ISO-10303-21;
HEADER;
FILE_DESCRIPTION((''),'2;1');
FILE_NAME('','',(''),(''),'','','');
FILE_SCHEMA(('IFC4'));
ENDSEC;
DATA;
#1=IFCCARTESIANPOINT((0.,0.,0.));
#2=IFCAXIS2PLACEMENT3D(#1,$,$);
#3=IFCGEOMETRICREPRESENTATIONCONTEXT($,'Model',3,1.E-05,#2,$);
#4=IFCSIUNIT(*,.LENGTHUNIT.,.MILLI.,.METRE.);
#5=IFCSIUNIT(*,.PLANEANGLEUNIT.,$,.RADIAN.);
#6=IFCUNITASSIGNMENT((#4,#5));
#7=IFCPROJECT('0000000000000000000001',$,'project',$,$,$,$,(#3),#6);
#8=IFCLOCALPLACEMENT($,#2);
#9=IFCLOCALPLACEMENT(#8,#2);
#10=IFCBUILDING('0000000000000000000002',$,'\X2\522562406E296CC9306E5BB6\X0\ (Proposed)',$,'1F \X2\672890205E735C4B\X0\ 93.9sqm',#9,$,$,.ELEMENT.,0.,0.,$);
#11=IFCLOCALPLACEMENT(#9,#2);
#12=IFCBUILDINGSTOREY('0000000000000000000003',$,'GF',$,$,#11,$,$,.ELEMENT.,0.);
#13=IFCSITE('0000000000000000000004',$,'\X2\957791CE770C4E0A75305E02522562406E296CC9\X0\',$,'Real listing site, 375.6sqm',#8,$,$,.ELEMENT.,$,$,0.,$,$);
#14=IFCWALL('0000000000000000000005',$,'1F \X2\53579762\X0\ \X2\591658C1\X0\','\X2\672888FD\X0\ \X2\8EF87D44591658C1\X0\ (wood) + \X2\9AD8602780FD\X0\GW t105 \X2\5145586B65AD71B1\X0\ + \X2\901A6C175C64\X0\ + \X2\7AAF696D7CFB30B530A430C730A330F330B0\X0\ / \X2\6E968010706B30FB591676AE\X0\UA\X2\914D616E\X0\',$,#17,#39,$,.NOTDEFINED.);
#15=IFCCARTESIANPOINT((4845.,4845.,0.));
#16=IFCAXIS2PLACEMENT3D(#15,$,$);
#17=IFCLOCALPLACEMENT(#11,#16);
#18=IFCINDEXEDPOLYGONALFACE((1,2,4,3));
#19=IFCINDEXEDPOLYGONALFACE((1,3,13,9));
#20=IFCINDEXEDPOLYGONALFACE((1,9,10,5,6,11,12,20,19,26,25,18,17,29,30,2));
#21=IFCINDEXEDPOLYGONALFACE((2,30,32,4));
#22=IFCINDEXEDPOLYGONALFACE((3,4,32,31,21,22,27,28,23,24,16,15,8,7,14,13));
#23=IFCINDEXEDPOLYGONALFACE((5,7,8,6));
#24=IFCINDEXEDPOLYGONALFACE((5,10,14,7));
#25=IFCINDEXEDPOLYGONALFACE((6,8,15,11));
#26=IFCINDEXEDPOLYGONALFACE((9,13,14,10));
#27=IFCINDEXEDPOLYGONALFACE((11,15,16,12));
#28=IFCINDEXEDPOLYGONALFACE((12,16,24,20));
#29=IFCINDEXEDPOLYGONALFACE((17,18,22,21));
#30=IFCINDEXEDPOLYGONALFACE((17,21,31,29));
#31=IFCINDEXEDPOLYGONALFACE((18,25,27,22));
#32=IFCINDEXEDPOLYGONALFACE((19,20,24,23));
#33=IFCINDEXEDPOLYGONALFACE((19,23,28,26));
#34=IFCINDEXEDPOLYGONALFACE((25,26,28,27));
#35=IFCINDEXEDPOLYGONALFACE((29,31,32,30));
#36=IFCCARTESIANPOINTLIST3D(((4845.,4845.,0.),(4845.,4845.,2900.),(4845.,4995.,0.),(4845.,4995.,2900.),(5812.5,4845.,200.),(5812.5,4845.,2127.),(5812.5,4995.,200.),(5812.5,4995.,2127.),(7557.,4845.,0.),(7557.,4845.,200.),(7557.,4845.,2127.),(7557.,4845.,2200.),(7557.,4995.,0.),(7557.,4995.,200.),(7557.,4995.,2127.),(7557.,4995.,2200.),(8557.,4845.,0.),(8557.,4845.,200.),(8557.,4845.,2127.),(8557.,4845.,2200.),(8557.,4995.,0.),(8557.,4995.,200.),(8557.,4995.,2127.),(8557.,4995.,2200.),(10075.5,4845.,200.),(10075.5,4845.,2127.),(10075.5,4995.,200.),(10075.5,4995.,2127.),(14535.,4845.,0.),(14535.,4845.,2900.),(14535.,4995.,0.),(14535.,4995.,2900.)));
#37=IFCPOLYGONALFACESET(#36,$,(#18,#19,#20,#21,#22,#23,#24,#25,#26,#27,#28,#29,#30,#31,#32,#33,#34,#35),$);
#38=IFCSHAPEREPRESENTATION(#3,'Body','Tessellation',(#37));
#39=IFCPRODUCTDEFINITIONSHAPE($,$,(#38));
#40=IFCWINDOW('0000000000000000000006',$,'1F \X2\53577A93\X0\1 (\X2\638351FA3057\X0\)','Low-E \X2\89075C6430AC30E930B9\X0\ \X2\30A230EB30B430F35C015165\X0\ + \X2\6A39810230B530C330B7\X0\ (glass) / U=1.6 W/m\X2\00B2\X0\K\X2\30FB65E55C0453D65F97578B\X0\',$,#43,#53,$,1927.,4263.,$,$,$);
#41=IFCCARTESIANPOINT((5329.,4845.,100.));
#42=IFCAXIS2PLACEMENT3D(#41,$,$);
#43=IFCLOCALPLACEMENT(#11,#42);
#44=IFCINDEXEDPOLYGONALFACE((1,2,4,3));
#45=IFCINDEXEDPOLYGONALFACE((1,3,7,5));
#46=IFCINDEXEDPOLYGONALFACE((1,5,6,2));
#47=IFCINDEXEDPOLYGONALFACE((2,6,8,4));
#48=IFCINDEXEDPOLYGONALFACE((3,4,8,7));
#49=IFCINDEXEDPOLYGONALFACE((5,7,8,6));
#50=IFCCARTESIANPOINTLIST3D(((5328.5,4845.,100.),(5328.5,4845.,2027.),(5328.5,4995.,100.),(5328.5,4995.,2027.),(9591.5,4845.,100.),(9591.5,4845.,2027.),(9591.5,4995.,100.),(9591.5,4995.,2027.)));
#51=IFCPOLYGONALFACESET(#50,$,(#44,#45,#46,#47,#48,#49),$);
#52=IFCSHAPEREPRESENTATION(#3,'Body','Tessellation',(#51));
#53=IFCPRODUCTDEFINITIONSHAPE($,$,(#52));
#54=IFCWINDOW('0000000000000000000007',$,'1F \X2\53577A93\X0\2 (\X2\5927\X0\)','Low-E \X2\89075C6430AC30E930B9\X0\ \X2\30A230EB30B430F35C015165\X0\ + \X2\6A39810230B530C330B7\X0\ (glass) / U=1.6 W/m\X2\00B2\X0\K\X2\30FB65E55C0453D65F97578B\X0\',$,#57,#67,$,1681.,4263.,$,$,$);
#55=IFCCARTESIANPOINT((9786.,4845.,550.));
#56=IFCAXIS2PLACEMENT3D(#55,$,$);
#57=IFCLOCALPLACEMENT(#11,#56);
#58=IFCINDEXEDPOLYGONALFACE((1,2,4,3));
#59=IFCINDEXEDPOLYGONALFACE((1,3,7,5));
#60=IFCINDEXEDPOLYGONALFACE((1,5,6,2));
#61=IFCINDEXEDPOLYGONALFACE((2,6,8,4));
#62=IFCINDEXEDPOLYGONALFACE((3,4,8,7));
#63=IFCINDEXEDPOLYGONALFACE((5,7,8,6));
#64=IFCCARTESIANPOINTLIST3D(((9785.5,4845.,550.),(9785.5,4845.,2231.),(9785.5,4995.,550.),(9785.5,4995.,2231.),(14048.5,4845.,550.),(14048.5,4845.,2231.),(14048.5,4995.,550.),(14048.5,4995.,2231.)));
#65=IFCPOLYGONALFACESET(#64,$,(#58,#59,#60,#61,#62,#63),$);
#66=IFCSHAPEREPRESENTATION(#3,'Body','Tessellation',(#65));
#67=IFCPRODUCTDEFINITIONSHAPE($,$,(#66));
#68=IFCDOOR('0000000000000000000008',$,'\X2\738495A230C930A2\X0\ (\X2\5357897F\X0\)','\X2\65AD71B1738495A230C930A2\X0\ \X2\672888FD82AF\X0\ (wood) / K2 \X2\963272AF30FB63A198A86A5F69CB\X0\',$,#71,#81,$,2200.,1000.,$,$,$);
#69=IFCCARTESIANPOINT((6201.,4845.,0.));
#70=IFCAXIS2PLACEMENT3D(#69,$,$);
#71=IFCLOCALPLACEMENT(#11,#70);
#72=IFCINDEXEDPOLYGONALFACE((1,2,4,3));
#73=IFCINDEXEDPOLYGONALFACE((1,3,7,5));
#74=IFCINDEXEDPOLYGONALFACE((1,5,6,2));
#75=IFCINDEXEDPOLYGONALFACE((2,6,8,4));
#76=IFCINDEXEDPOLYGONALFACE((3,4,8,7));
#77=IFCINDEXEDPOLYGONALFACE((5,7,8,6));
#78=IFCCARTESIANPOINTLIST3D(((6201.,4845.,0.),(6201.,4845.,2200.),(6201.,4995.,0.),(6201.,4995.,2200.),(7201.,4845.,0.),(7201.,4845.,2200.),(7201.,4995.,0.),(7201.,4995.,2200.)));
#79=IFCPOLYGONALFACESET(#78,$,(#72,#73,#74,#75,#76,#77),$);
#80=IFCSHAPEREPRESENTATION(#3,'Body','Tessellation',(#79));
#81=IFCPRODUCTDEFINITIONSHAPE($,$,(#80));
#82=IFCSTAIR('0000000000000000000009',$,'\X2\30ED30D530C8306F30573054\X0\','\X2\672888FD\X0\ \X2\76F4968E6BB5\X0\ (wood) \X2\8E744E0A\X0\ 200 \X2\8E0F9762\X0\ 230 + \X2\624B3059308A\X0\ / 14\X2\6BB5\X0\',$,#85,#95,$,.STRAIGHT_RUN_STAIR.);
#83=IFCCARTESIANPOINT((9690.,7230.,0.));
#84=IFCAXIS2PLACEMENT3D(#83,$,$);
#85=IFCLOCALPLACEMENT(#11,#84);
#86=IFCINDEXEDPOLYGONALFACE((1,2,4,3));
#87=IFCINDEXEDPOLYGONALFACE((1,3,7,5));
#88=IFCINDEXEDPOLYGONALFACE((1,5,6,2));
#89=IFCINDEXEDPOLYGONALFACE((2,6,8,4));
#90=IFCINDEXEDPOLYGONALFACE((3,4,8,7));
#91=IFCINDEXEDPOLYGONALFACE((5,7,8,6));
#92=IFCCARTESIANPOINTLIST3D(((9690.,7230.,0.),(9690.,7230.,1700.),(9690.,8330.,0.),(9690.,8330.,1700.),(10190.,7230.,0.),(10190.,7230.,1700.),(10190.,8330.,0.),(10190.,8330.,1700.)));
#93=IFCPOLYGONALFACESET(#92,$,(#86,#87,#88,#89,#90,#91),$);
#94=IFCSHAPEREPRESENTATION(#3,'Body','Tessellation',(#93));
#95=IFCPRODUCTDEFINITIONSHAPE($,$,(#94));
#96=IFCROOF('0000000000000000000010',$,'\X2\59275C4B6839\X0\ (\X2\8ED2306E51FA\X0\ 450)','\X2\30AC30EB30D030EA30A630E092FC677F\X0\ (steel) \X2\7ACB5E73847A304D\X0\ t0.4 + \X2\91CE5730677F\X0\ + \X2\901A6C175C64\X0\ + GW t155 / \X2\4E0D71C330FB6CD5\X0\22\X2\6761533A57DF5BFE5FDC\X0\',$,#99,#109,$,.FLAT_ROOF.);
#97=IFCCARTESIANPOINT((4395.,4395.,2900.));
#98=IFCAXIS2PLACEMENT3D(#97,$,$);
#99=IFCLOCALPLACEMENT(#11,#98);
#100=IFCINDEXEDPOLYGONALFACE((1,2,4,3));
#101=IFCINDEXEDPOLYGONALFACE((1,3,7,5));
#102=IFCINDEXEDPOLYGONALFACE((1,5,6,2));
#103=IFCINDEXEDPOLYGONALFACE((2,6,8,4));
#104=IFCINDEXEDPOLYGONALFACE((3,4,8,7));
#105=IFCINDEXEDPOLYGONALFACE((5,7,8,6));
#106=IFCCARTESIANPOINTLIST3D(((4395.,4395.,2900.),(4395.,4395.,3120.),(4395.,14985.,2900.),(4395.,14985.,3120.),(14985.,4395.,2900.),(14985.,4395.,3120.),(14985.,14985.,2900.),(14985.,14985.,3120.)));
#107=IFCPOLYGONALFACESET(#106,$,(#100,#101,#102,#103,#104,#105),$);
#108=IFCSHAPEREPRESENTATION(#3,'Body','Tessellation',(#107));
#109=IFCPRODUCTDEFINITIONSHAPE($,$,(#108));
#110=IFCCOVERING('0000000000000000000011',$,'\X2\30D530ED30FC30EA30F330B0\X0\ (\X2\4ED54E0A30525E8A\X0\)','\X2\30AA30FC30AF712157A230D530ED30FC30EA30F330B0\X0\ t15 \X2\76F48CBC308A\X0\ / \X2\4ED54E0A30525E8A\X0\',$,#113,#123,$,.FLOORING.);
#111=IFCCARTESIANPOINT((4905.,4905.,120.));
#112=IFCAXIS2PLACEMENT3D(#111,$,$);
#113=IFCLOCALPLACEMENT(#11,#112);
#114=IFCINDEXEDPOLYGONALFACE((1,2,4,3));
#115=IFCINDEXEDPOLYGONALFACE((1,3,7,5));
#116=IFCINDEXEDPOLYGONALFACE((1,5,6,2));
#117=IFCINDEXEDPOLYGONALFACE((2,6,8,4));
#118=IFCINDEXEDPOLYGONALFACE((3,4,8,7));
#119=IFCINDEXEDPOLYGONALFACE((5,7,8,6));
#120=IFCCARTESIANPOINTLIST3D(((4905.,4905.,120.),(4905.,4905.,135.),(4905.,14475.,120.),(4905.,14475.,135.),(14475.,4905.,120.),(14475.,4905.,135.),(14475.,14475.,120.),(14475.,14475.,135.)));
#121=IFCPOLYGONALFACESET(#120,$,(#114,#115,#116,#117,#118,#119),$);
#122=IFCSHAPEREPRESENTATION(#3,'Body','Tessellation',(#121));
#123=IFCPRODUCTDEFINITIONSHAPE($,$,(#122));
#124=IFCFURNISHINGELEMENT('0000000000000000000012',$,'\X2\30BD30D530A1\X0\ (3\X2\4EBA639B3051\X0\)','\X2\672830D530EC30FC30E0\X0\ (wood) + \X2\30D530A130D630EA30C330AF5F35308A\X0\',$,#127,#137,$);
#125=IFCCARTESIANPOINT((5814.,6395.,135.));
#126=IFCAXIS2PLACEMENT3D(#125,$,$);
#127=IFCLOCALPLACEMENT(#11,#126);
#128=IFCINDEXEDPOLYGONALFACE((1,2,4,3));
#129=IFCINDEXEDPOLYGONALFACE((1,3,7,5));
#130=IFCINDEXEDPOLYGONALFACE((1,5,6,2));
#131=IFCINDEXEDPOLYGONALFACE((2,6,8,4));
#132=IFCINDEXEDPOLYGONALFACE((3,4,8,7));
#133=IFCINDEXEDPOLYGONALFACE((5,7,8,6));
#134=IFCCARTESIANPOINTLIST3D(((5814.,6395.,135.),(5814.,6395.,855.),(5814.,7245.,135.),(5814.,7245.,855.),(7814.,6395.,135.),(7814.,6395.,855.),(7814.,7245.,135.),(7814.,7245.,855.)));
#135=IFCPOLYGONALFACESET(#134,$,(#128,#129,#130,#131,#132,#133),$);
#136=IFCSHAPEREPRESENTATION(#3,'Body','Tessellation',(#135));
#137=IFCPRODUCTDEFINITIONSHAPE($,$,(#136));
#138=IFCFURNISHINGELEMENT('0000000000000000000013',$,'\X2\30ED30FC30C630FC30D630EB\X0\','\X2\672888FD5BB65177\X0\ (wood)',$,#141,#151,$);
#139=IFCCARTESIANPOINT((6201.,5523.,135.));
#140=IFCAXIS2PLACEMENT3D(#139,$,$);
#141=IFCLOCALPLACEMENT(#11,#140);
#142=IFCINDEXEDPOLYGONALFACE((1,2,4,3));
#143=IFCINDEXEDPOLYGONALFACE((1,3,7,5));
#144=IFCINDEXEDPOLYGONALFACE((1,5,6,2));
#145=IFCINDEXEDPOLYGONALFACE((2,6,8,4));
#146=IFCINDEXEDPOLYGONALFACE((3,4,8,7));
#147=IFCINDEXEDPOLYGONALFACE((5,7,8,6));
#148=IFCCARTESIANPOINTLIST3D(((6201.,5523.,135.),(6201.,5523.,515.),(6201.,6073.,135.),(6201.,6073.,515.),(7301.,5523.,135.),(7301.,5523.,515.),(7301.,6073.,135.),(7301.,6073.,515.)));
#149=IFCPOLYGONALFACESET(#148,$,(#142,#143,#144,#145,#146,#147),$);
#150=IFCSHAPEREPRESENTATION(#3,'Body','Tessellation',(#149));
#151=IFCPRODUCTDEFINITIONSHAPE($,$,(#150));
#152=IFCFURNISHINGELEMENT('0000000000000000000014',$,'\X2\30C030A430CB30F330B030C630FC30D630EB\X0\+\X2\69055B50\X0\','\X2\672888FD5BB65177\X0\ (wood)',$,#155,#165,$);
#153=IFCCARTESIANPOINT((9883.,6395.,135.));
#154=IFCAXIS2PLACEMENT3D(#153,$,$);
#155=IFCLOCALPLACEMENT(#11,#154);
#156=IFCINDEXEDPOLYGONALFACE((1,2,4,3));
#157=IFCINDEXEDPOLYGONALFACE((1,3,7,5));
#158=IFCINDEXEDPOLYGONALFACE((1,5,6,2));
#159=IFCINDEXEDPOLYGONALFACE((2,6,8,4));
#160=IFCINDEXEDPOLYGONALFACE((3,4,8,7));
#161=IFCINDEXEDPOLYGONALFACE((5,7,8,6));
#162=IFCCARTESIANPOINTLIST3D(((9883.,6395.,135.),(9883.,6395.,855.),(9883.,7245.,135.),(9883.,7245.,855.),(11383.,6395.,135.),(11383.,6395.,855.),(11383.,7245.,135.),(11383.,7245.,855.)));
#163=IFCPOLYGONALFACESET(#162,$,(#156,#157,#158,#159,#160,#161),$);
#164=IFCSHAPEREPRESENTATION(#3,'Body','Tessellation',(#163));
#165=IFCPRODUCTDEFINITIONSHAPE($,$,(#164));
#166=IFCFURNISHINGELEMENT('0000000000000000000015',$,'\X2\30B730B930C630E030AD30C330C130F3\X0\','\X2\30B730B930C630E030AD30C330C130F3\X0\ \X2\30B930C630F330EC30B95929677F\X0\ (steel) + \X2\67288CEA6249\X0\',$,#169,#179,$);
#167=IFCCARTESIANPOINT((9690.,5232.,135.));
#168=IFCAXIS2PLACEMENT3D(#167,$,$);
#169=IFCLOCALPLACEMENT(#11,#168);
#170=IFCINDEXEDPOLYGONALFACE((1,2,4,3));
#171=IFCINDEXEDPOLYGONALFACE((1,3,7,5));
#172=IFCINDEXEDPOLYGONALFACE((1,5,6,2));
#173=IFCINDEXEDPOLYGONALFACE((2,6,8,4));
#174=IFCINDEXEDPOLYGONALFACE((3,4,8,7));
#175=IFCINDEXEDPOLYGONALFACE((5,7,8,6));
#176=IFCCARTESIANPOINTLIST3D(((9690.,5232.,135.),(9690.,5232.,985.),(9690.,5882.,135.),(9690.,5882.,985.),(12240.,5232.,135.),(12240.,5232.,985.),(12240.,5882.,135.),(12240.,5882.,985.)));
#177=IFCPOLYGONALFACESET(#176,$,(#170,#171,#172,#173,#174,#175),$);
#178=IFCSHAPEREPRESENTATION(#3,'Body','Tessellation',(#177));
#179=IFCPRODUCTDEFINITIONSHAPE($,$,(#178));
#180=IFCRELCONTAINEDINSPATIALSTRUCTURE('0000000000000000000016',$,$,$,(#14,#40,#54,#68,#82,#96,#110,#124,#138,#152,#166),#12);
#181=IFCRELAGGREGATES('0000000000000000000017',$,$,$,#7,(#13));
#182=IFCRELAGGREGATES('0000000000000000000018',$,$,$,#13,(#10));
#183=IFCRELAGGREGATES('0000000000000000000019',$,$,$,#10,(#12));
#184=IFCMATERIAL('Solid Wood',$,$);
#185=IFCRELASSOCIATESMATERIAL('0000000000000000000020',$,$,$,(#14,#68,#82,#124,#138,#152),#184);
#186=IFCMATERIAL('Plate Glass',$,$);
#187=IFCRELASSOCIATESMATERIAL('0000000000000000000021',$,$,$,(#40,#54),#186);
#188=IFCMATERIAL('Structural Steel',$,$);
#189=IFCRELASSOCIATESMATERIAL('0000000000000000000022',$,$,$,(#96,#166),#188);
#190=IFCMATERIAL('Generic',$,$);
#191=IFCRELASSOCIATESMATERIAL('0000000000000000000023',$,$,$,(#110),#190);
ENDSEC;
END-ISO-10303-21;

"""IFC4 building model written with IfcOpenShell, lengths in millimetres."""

from ifc_helpers import new_model, si_unit, frame, frame_2d, origin, place, context, project, spatial, rectangle, extrude, material, element, fill, save


model = new_model("IFC4")

# Units and contexts
model_context = context("Model", 3, precision=1e-05, world=origin())
ifc_project = project(units=[si_unit("LENGTHUNIT", "METRE", prefix="MILLI"), si_unit("PLANEANGLEUNIT", "RADIAN")], contexts=[model_context])

# Site, building, storey
site_placement = place(None, origin())
site = spatial("IfcSite", under=ifc_project, at=site_placement, Name="長野県上田市別所温泉", ObjectType="Real listing site, 375.6sqm", CompositionType="ELEMENT", RefElevation=0.0)
building_placement = place(site_placement, origin())
building = spatial("IfcBuilding", under=site, at=building_placement, Name="別所温泉の家 (Proposed)", ObjectType="1F 木造平屋 93.9sqm", CompositionType="ELEMENT", ElevationOfRefHeight=0.0, ElevationOfTerrain=0.0)
storey_placement = place(building_placement, origin())
storey = spatial("IfcBuildingStorey", under=building, at=storey_placement, Name="GF", CompositionType="ELEMENT", Elevation=0.0)

# Shared definitions
ifc_material_1 = material(Name="Solid Wood")

# Wall, openings, windows, door
wall_1_placement = place(storey_placement, frame((4845.0, 4845.0, 0.0)))
wall_1 = element("IfcWall", 1, at=wall_1_placement, inside=storey, material=ifc_material_1, Name="1F 南面 外壁", Description="木製 軸組外壁 (wood) + 高性能GW t105 充填断熱 + 通気層 + 窯業系サイディング / 準耐火・外皮UA配慮", PredefinedType="NOTDEFINED", context=model_context, shape_type="SweptSolid", body=[
    extrude(rectangle(XDim=9690.0, YDim=150.0, at=frame_2d((4845.0, 75.0))), frame((4845.0, 4845.0, 0.0)), (0.0, 0.0, 1.0), 2900.0),
])
opening_1_placement = place(storey_placement, frame((5329.0, 4845.0, 100.0)))
opening_1 = element("IfcOpeningElement", 2, at=opening_1_placement, cuts=wall_1, PredefinedType="NOTDEFINED", context=model_context, shape_type="SweptSolid", body=[
    extrude(rectangle(XDim=4263.0, YDim=150.0, at=frame_2d((2131.0, 75.0))), frame((5329.0, 4845.0, 100.0)), (0.0, 0.0, 1.0), 1927.0),
])
opening_2_placement = place(storey_placement, frame((9786.0, 4845.0, 550.0)))
opening_2 = element("IfcOpeningElement", 3, at=opening_2_placement, cuts=wall_1, PredefinedType="NOTDEFINED", context=model_context, shape_type="SweptSolid", body=[
    extrude(rectangle(XDim=4263.0, YDim=150.0, at=frame_2d((2131.0, 75.0))), frame((9786.0, 4845.0, 550.0)), (0.0, 0.0, 1.0), 1681.0),
])
opening_3_placement = place(storey_placement, frame((6201.0, 4845.0, 0.0)))
opening_3 = element("IfcOpeningElement", 4, at=opening_3_placement, cuts=wall_1, PredefinedType="NOTDEFINED", context=model_context, shape_type="SweptSolid", body=[
    extrude(rectangle(XDim=1000.0, YDim=150.0, at=frame_2d((500.0, 75.0))), frame((6201.0, 4845.0, 0.0)), (0.0, 0.0, 1.0), 2200.0),
])
ifc_material_2 = material(Name="Plate Glass")
window_1_placement = place(storey_placement, frame((5329.0, 4845.0, 100.0)))
window_1 = element("IfcWindow", 5, at=window_1_placement, inside=storey, material=ifc_material_2, Name="1F 南窓1 (掃出し)", Description="Low-E 複層ガラス アルゴン封入 + 樹脂サッシ (glass) / U=1.6 W/m²K・日射取得型", OverallHeight=1927.0, OverallWidth=4263.0, context=model_context, shape_type="SweptSolid", body=[
    extrude(rectangle(XDim=4263.0, YDim=150.0, at=frame_2d((2131.0, 75.0))), frame((5329.0, 4845.0, 100.0)), (0.0, 0.0, 1.0), 1927.0),
])
fill(opening_1, window_1)
window_2_placement = place(storey_placement, frame((9786.0, 4845.0, 550.0)))
window_2 = element("IfcWindow", 6, at=window_2_placement, inside=storey, material=ifc_material_2, Name="1F 南窓2 (大)", Description="Low-E 複層ガラス アルゴン封入 + 樹脂サッシ (glass) / U=1.6 W/m²K・日射取得型", OverallHeight=1681.0, OverallWidth=4263.0, context=model_context, shape_type="SweptSolid", body=[
    extrude(rectangle(XDim=4263.0, YDim=150.0, at=frame_2d((2131.0, 75.0))), frame((9786.0, 4845.0, 550.0)), (0.0, 0.0, 1.0), 1681.0),
])
fill(opening_2, window_2)
door_placement = place(storey_placement, frame((6201.0, 4845.0, 0.0)))
door = element("IfcDoor", 7, at=door_placement, inside=storey, material=ifc_material_1, Name="玄関ドア (南西)", Description="断熱玄関ドア 木製芯 (wood) / K2 防犯・採風機構", OverallHeight=2200.0, OverallWidth=1000.0, context=model_context, shape_type="SweptSolid", body=[
    extrude(rectangle(XDim=1000.0, YDim=150.0, at=frame_2d((500.0, 75.0))), frame((6201.0, 4845.0, 0.0)), (0.0, 0.0, 1.0), 2200.0),
])
fill(opening_3, door)

# Stair
stair_placement = place(storey_placement, frame((9690.0, 7230.0, 0.0)))
element("IfcStair", 8, at=stair_placement, inside=storey, material=ifc_material_1, Name="ロフトはしご", Description="木製 直階段 (wood) 蹴上 200 踏面 230 + 手すり / 14段", PredefinedType="STRAIGHT_RUN_STAIR", context=model_context, shape_type="SweptSolid", body=[
    extrude(rectangle(XDim=500.0, YDim=1100.0, at=frame_2d((250.0, 550.0))), frame((9690.0, 7230.0, 0.0)), (0.0, 0.0, 1.0), 1700.0),
])

# Roof
ifc_material_3 = material(Name="Structural Steel")
roof_placement = place(storey_placement, frame((4395.0, 4395.0, 2900.0)))
element("IfcRoof", 9, at=roof_placement, inside=storey, material=ifc_material_3, Name="大屋根 (軒の出 450)", Description="ガルバリウム鋼板 (steel) 立平葺き t0.4 + 野地板 + 通気層 + GW t155 / 不燃・法22条区域対応", PredefinedType="FLAT_ROOF", context=model_context, shape_type="SweptSolid", body=[
    extrude(rectangle(XDim=10590.0, YDim=10590.0, at=frame_2d((5295.0, 5295.0))), frame((4395.0, 4395.0, 2900.0)), (0.0, 0.0, 1.0), 220.0),
])

# Covering
ifc_material_4 = material(Name="Generic")
covering_placement = place(storey_placement, frame((4905.0, 4905.0, 120.0)))
element("IfcCovering", 10, at=covering_placement, inside=storey, material=ifc_material_4, Name="フローリング (仕上げ床)", Description="オーク無垢フローリング t15 直貼り / 仕上げ床", PredefinedType="FLOORING", context=model_context, shape_type="SweptSolid", body=[
    extrude(rectangle(XDim=9570.0, YDim=9570.0, at=frame_2d((4785.0, 4785.0))), frame((4905.0, 4905.0, 120.0)), (0.0, 0.0, 1.0), 15.0),
])

# Furnishing elements
furnishing_1_placement = place(storey_placement, frame((5814.0, 6395.0, 135.0)))
element("IfcFurnishingElement", 11, at=furnishing_1_placement, inside=storey, material=ifc_material_1, Name="ソファ (3人掛け)", Description="木フレーム (wood) + ファブリック張り", context=model_context, shape_type="SweptSolid", body=[
    extrude(rectangle(XDim=2000.0, YDim=850.0, at=frame_2d((1000.0, 425.0))), frame((5814.0, 6395.0, 135.0)), (0.0, 0.0, 1.0), 720.0),
])
furnishing_2_placement = place(storey_placement, frame((6201.0, 5523.0, 135.0)))
element("IfcFurnishingElement", 12, at=furnishing_2_placement, inside=storey, material=ifc_material_1, Name="ローテーブル", Description="木製家具 (wood)", context=model_context, shape_type="SweptSolid", body=[
    extrude(rectangle(XDim=1100.0, YDim=550.0, at=frame_2d((550.0, 275.0))), frame((6201.0, 5523.0, 135.0)), (0.0, 0.0, 1.0), 380.0),
])
furnishing_3_placement = place(storey_placement, frame((9883.0, 6395.0, 135.0)))
element("IfcFurnishingElement", 13, at=furnishing_3_placement, inside=storey, material=ifc_material_1, Name="ダイニングテーブル+椅子", Description="木製家具 (wood)", context=model_context, shape_type="SweptSolid", body=[
    extrude(rectangle(XDim=1500.0, YDim=850.0, at=frame_2d((750.0, 425.0))), frame((9883.0, 6395.0, 135.0)), (0.0, 0.0, 1.0), 720.0),
])
furnishing_4_placement = place(storey_placement, frame((9690.0, 5232.0, 135.0)))
element("IfcFurnishingElement", 14, at=furnishing_4_placement, inside=storey, material=ifc_material_3, Name="システムキッチン", Description="システムキッチン ステンレス天板 (steel) + 木質扉", context=model_context, shape_type="SweptSolid", body=[
    extrude(rectangle(XDim=2550.0, YDim=650.0, at=frame_2d((1275.0, 325.0))), frame((9690.0, 5232.0, 135.0)), (0.0, 0.0, 1.0), 850.0),
])

save(model, "model.ifc")
